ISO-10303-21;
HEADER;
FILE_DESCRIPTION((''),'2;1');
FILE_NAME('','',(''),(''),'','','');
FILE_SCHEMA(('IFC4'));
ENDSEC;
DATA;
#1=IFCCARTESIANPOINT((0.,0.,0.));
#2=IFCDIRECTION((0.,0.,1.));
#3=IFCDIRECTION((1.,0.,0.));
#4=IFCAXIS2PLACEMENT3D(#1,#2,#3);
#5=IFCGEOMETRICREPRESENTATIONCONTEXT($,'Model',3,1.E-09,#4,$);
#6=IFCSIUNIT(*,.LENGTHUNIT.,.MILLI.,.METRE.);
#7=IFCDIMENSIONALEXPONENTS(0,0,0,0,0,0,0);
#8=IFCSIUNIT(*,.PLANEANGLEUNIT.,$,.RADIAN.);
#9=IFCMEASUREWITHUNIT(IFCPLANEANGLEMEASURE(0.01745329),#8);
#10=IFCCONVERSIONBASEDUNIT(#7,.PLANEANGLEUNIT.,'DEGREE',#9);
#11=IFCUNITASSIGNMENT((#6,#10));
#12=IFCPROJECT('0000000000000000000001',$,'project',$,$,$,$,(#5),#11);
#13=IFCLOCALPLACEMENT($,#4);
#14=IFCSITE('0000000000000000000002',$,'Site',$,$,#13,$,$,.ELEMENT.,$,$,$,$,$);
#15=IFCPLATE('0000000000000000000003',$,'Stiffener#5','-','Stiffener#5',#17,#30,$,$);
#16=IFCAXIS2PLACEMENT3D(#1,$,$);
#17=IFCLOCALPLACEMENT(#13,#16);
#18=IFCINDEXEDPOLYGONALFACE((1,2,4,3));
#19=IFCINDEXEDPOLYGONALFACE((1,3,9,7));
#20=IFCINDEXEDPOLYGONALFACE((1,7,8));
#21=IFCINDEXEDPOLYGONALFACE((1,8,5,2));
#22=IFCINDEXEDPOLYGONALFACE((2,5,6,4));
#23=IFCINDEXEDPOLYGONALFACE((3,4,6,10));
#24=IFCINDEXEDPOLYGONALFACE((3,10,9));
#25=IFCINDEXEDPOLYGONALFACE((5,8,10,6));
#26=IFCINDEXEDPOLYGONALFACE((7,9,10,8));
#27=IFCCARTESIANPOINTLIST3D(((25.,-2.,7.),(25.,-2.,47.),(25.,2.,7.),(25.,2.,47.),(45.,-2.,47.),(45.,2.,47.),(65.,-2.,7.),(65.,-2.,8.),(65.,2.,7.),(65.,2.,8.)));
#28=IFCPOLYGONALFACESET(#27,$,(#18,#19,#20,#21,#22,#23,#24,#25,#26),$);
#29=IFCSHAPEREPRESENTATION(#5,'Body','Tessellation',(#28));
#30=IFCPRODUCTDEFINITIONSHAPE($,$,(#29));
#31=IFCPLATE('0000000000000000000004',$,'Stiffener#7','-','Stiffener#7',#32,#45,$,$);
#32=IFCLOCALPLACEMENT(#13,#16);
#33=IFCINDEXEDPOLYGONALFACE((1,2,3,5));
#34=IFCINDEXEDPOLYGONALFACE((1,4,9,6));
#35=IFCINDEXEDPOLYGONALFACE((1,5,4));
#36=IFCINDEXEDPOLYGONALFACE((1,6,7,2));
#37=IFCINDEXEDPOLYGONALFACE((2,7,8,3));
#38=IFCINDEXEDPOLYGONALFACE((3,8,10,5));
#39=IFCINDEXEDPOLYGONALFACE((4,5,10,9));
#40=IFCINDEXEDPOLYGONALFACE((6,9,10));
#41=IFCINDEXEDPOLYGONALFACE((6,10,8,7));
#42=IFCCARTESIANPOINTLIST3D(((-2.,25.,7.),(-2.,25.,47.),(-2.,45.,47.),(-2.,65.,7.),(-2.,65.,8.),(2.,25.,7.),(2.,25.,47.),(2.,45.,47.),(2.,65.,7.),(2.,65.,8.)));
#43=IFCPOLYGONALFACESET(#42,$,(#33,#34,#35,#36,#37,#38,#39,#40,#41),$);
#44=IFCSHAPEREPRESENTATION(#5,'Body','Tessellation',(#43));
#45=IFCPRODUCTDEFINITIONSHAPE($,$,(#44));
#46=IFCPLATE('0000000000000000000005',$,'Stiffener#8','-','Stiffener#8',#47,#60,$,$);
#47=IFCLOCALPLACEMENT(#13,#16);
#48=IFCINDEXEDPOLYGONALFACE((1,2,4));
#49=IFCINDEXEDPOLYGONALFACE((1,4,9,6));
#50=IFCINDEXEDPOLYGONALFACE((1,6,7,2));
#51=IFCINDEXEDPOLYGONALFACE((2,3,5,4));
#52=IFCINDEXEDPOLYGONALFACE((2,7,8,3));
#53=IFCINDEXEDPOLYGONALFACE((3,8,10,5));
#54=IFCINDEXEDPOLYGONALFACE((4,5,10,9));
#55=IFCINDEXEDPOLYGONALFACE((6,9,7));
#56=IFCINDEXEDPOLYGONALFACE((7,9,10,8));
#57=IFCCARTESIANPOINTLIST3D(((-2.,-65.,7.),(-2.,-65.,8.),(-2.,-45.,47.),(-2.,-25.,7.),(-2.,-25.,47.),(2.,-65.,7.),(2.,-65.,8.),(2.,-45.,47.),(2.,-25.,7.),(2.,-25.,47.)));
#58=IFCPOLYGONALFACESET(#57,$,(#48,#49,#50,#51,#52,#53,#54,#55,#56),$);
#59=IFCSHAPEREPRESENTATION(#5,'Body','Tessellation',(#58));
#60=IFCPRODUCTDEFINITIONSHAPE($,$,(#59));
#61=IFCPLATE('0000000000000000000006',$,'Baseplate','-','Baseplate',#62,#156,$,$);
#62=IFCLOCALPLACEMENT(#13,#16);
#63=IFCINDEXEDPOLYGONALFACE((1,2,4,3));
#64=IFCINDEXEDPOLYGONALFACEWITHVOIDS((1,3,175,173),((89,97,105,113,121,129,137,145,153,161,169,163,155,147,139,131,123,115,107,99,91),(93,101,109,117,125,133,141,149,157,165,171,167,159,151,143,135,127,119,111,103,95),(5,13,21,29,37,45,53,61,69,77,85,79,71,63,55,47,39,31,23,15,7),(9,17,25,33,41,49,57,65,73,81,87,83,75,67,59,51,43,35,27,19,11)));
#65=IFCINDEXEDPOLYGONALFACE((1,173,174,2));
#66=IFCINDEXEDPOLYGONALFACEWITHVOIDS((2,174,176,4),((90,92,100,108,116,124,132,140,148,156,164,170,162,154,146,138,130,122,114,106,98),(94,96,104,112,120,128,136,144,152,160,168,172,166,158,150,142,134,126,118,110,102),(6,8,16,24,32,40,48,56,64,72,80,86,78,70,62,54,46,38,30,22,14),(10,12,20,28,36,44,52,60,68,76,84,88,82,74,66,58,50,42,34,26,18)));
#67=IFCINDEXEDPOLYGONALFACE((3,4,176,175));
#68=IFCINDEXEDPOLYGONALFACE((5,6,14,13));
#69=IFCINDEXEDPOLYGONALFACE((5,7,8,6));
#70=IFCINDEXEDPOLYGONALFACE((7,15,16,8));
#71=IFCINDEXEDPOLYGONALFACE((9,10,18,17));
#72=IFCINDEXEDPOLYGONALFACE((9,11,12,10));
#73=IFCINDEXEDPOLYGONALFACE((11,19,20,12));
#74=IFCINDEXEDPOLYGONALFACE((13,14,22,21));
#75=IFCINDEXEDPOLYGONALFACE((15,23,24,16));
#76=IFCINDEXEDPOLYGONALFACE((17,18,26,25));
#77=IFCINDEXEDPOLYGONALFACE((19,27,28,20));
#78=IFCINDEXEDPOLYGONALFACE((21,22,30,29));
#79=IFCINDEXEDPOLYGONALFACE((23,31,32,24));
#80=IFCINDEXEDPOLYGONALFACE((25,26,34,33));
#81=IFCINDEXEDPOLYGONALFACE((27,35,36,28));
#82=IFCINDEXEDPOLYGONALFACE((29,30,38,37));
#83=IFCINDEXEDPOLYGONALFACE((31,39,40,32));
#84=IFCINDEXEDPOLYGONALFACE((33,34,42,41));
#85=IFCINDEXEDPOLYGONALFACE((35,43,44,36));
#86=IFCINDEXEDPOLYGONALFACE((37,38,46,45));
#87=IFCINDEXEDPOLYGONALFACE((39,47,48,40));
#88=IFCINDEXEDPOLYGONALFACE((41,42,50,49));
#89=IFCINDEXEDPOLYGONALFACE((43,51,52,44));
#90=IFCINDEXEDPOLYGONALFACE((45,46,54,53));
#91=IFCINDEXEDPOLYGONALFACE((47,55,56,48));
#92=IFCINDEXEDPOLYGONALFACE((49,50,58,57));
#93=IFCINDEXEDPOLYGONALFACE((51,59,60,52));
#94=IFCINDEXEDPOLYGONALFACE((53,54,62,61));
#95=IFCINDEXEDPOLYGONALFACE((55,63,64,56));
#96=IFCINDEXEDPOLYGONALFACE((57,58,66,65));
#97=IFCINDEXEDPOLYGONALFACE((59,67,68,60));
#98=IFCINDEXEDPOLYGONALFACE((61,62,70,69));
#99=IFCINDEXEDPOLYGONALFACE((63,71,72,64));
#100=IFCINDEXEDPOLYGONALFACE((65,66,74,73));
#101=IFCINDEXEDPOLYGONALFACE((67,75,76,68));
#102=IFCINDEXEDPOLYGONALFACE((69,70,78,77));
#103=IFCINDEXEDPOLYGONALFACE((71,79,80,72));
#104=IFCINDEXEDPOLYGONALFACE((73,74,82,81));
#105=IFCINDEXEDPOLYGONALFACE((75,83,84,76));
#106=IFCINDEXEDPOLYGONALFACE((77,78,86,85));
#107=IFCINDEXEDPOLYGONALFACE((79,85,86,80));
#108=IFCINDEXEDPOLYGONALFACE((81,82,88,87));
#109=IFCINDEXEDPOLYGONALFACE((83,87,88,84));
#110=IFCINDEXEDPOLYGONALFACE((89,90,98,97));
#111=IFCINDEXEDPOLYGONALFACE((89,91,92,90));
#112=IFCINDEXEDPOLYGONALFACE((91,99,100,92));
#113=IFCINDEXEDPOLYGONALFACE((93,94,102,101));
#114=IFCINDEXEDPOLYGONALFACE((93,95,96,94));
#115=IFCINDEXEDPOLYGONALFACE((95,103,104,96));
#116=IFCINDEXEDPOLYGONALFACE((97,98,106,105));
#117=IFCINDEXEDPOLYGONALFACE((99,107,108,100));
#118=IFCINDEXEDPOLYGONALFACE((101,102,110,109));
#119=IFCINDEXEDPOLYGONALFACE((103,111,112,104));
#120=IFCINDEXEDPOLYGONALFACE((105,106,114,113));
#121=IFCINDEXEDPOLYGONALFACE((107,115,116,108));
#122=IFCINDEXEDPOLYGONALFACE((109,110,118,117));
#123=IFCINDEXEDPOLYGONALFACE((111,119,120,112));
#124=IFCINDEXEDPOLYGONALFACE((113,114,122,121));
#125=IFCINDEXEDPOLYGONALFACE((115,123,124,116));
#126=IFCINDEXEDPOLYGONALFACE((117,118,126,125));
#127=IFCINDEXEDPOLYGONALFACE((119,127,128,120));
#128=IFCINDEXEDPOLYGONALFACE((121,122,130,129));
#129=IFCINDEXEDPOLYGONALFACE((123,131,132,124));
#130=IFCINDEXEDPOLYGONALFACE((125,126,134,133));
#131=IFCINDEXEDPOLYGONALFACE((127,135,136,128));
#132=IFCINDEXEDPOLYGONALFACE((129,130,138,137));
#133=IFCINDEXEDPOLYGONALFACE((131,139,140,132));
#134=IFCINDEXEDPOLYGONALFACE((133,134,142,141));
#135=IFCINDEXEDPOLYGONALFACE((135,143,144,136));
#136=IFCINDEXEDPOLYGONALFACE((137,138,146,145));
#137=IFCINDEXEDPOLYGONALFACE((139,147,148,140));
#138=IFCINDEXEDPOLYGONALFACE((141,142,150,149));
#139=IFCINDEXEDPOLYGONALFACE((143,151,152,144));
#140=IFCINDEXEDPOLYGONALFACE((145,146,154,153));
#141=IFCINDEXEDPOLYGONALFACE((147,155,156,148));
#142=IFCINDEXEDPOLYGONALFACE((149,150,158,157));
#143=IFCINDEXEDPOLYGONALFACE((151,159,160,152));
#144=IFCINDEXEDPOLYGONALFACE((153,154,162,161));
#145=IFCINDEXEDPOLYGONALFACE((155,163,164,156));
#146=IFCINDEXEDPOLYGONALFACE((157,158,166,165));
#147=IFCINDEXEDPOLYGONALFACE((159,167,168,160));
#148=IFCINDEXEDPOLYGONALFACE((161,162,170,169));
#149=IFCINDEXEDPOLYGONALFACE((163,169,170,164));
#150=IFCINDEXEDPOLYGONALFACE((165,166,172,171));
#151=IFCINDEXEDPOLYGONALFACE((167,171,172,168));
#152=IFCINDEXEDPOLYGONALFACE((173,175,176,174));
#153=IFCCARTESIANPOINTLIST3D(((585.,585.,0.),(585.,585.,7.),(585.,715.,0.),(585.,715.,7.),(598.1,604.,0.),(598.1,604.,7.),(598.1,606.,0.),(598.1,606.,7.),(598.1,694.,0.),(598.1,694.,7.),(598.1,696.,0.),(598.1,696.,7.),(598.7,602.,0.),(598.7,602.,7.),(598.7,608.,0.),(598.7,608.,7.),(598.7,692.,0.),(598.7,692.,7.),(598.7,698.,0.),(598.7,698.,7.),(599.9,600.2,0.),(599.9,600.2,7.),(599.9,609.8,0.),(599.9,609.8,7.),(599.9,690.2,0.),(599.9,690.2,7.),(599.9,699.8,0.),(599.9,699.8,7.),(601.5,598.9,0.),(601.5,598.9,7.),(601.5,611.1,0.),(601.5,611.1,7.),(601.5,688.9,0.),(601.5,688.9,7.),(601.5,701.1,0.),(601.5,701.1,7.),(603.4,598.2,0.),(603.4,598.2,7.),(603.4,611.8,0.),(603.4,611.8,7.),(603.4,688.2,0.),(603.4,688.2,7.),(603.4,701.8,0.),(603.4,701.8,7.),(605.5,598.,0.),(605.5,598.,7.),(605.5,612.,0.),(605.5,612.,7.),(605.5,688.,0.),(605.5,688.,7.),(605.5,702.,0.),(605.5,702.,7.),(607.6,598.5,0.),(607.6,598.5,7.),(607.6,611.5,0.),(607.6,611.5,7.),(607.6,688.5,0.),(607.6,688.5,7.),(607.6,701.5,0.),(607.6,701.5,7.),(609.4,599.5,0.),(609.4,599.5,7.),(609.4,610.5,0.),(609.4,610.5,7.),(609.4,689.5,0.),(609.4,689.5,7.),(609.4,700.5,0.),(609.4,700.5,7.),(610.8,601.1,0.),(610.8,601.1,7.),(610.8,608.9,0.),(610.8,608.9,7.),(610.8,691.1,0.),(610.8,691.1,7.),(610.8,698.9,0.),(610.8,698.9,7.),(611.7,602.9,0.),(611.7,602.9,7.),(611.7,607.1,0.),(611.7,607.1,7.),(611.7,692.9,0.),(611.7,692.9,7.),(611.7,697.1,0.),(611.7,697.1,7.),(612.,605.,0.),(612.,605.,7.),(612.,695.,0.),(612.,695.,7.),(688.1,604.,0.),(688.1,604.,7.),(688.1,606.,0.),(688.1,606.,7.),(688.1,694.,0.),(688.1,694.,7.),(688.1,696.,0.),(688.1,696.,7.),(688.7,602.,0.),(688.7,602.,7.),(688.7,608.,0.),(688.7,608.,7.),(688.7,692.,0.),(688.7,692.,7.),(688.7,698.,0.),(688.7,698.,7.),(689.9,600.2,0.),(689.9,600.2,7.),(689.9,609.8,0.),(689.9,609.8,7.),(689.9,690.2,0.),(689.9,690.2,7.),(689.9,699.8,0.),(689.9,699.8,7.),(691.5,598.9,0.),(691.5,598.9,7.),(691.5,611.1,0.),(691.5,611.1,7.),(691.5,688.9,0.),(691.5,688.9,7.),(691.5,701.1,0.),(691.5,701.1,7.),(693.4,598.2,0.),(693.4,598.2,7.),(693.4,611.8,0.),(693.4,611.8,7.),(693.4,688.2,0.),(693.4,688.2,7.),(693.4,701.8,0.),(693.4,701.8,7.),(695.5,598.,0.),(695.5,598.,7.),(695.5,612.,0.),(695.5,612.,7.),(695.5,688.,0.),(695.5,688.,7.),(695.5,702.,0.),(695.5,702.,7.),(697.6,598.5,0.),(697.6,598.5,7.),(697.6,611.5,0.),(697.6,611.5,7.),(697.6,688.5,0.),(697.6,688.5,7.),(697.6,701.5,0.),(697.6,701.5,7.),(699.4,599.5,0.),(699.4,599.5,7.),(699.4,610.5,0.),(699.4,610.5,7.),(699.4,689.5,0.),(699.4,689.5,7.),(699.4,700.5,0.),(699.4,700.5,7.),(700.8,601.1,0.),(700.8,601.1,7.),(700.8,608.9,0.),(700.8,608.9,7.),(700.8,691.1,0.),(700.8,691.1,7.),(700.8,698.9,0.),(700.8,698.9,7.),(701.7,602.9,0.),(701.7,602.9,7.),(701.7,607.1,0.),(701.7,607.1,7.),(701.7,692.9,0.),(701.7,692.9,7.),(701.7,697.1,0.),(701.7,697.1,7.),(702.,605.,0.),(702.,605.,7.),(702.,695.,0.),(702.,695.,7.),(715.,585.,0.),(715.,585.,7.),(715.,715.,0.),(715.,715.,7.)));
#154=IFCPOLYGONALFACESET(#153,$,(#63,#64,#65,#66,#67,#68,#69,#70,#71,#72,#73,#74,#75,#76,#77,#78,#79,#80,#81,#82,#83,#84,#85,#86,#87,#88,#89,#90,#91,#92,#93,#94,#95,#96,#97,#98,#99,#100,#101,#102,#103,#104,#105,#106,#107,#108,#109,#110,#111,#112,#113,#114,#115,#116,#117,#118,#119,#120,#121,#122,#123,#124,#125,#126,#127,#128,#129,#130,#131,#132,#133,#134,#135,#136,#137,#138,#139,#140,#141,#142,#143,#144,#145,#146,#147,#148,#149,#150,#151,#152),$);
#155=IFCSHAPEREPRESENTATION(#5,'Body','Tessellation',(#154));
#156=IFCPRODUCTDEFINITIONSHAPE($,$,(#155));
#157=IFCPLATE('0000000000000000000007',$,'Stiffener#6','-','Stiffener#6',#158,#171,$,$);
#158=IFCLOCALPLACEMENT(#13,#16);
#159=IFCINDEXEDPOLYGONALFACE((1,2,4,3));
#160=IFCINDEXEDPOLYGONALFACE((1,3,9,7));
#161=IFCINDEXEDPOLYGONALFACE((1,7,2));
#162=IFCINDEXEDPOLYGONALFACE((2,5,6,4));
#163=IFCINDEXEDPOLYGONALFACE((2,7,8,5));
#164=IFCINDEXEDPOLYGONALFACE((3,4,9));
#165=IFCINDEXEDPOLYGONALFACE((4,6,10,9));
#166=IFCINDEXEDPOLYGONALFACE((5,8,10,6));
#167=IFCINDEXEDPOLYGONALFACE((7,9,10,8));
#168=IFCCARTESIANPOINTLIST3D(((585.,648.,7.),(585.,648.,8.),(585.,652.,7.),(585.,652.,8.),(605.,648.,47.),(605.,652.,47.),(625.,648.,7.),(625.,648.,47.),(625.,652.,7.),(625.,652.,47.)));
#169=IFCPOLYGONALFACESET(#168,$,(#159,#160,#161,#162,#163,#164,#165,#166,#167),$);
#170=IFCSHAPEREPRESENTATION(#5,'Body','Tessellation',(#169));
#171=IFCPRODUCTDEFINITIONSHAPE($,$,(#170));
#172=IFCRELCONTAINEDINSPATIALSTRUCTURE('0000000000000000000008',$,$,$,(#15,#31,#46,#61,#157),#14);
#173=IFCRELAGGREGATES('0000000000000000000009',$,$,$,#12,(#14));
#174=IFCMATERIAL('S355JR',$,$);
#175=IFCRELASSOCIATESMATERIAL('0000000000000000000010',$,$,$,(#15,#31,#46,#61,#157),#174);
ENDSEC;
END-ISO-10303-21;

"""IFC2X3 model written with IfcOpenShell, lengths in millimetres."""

from ifc_helpers import new_model, entity, si_unit, converted_unit, frame, frame_2d, origin, origin_with_axes, place, context, project, spatial, polyline, circle, outline, extrude, material, element, save


model = new_model("IFC2X3")

# Units and contexts
model_context = context("Model", 3, precision=1e-09, world=origin_with_axes())
ifc_project = project(units=[si_unit("LENGTHUNIT", "METRE", prefix="MILLI"), converted_unit("PLANEANGLEUNIT", "DEGREE", entity("IfcPlaneAngleMeasure", 0.01745329), si_unit("PLANEANGLEUNIT", "RADIAN"), dimensions=[0, 0, 0, 0, 0, 0, 0])], contexts=[model_context])

# Site
site_placement = place(None, origin_with_axes())
site = spatial("IfcSite", under=ifc_project, at=site_placement, Name="Site", CompositionType="ELEMENT")

# Plates, openings
ifc_material = material(Name="S355JR")
plate_1_placement = place(None, frame((25.0, -2.0, 7.0), z_axis=(0.0, 1.0, 0.0), x_axis=(0.0, 0.0, 1.0)))
plate_1 = element("IfcPlate", 1, at=plate_1_placement, inside=site, material=ifc_material, Name="Stiffener#5", Description="-", ObjectType="Stiffener#5", context=model_context, shape_type="SweptSolid", body=[
    extrude(outline(polyline([(0.0, 0.0), (40.0, 0.0), (40.0, 40.0), (0.0, 40.0), (0.0, 0.0)])), origin_with_axes(), (0.0, 0.0, 1.0), 4.0),
])
opening_1_placement = place(plate_1_placement, frame((0.0, 0.0, 0.0), z_axis=(0.0, 0.0, 1.0), x_axis=(1.0, 0.0, 0.0)))
element("IfcOpeningElement", 2, at=opening_1_placement, cuts=plate_1, ObjectType="Opening", context=model_context, shape_type="SweptSolid", body=[
    extrude(outline(polyline([(40.0, 40.0), (1.0, 40.0), (40.0, 20.0), (40.0, 40.0)])), origin(), (0.0, 0.0, 1.0), 4.0),
])
plate_2_placement = place(None, frame((2.0, 25.0, 7.0), z_axis=(-1.0, 0.0, 0.0), x_axis=(0.0, 0.0, 1.0)))
plate_2 = element("IfcPlate", 3, at=plate_2_placement, inside=site, material=ifc_material, Name="Stiffener#7", Description="-", ObjectType="Stiffener#7", context=model_context, shape_type="SweptSolid", body=[
    extrude(outline(polyline([(0.0, 0.0), (40.0, 0.0), (40.0, 40.0), (0.0, 40.0), (0.0, 0.0)])), origin_with_axes(), (0.0, 0.0, 1.0), 4.0),
])
opening_2_placement = place(plate_2_placement, frame((0.0, 0.0, 0.0), z_axis=(0.0, 0.0, 1.0), x_axis=(1.0, 0.0, 0.0)))
element("IfcOpeningElement", 4, at=opening_2_placement, cuts=plate_2, ObjectType="Opening", context=model_context, shape_type="SweptSolid", body=[
    extrude(outline(polyline([(40.0, 40.0), (1.0, 40.0), (40.0, 20.0), (40.0, 40.0)])), origin(), (0.0, 0.0, 1.0), 4.0),
])
plate_3_placement = place(None, frame((2.0, -25.0, 7.0), z_axis=(-1.0, 0.0, 0.0), x_axis=(0.0, -1.0, 0.0)))
plate_3 = element("IfcPlate", 5, at=plate_3_placement, inside=site, material=ifc_material, Name="Stiffener#8", Description="-", ObjectType="Stiffener#8", context=model_context, shape_type="SweptSolid", body=[
    extrude(outline(polyline([(0.0, 0.0), (40.0, 0.0), (40.0, 40.0), (0.0, 40.0), (0.0, 0.0)])), origin_with_axes(), (0.0, 0.0, 1.0), 4.0),
])
opening_3_placement = place(plate_3_placement, frame((0.0, 0.0, 0.0), z_axis=(0.0, 0.0, 1.0), x_axis=(1.0, 0.0, 0.0)))
element("IfcOpeningElement", 6, at=opening_3_placement, cuts=plate_3, ObjectType="Opening", context=model_context, shape_type="SweptSolid", body=[
    extrude(outline(polyline([(40.0, 40.0), (20.0, 40.0), (40.0, 1.0), (40.0, 40.0)])), origin(), (0.0, 0.0, 1.0), 4.0),
])

# Plate, openings
plate_4_placement = place(None, frame((585.0, 715.0, 7.0), z_axis=(0.0, 0.0, -1.0), x_axis=(1.0, 0.0, 0.0)))
plate_4 = element("IfcPlate", 7, at=plate_4_placement, inside=site, material=ifc_material, Name="Baseplate", Description="-", ObjectType="Baseplate", context=model_context, shape_type="SweptSolid", body=[
    extrude(outline(polyline([(0.0, 0.0), (130.0, 0.0), (130.0, 130.0), (0.0, 130.0), (0.0, 0.0)])), origin_with_axes(), (0.0, 0.0, 1.0), 7.0),
])
opening_4_placement = place(plate_4_placement, frame((20.0, 65.0, 7.5), z_axis=(0.0, 0.0, -1.0), x_axis=(1.0, 0.0, 0.0)))
element("IfcOpeningElement", 8, at=opening_4_placement, cuts=plate_4, ObjectType="Opening", context=model_context, shape_type="SweptSolid", body=[
    extrude(circle(Radius=7.0, at=frame_2d((0.0, 45.0), x_axis=(1.0, 0.0))), origin(), (0.0, 0.0, 1.0), 8.0),
])
opening_5_placement = place(plate_4_placement, frame((20.0, 65.0, 7.5), z_axis=(0.0, 0.0, -1.0), x_axis=(1.0, 0.0, 0.0)))
element("IfcOpeningElement", 9, at=opening_5_placement, cuts=plate_4, ObjectType="Opening", context=model_context, shape_type="SweptSolid", body=[
    extrude(circle(Radius=7.0, at=frame_2d((0.0, -45.0), x_axis=(1.0, 0.0))), origin(), (0.0, 0.0, 1.0), 8.0),
])
opening_6_placement = place(plate_4_placement, frame((110.0, 65.0, 7.5), z_axis=(0.0, 0.0, -1.0), x_axis=(1.0, 0.0, 0.0)))
element("IfcOpeningElement", 10, at=opening_6_placement, cuts=plate_4, ObjectType="Opening", context=model_context, shape_type="SweptSolid", body=[
    extrude(circle(Radius=7.0, at=frame_2d((0.0, 45.0), x_axis=(1.0, 0.0))), origin(), (0.0, 0.0, 1.0), 8.0),
])
opening_7_placement = place(plate_4_placement, frame((110.0, 65.0, 7.5), z_axis=(0.0, 0.0, -1.0), x_axis=(1.0, 0.0, 0.0)))
element("IfcOpeningElement", 11, at=opening_7_placement, cuts=plate_4, ObjectType="Opening", context=model_context, shape_type="SweptSolid", body=[
    extrude(circle(Radius=7.0, at=frame_2d((0.0, -45.0), x_axis=(1.0, 0.0))), origin(), (0.0, 0.0, 1.0), 8.0),
])

# Plate, opening
plate_5_placement = place(None, frame((625.0, 648.0, 7.0), z_axis=(0.0, 1.0, 0.0), x_axis=(-1.0, 0.0, 0.0)))
plate_5 = element("IfcPlate", 12, at=plate_5_placement, inside=site, material=ifc_material, Name="Stiffener#6", Description="-", ObjectType="Stiffener#6", context=model_context, shape_type="SweptSolid", body=[
    extrude(outline(polyline([(0.0, 0.0), (40.0, 0.0), (40.0, 40.0), (0.0, 40.0), (0.0, 0.0)])), origin_with_axes(), (0.0, 0.0, 1.0), 4.0),
])
opening_8_placement = place(plate_5_placement, frame((0.0, 0.0, 0.0), z_axis=(0.0, 0.0, 1.0), x_axis=(1.0, 0.0, 0.0)))
element("IfcOpeningElement", 13, at=opening_8_placement, cuts=plate_5, ObjectType="Opening", context=model_context, shape_type="SweptSolid", body=[
    extrude(outline(polyline([(40.0, 40.0), (20.0, 40.0), (40.0, 1.0), (40.0, 40.0)])), origin(), (0.0, 0.0, 1.0), 4.0),
])

save(model, "model.ifc")
